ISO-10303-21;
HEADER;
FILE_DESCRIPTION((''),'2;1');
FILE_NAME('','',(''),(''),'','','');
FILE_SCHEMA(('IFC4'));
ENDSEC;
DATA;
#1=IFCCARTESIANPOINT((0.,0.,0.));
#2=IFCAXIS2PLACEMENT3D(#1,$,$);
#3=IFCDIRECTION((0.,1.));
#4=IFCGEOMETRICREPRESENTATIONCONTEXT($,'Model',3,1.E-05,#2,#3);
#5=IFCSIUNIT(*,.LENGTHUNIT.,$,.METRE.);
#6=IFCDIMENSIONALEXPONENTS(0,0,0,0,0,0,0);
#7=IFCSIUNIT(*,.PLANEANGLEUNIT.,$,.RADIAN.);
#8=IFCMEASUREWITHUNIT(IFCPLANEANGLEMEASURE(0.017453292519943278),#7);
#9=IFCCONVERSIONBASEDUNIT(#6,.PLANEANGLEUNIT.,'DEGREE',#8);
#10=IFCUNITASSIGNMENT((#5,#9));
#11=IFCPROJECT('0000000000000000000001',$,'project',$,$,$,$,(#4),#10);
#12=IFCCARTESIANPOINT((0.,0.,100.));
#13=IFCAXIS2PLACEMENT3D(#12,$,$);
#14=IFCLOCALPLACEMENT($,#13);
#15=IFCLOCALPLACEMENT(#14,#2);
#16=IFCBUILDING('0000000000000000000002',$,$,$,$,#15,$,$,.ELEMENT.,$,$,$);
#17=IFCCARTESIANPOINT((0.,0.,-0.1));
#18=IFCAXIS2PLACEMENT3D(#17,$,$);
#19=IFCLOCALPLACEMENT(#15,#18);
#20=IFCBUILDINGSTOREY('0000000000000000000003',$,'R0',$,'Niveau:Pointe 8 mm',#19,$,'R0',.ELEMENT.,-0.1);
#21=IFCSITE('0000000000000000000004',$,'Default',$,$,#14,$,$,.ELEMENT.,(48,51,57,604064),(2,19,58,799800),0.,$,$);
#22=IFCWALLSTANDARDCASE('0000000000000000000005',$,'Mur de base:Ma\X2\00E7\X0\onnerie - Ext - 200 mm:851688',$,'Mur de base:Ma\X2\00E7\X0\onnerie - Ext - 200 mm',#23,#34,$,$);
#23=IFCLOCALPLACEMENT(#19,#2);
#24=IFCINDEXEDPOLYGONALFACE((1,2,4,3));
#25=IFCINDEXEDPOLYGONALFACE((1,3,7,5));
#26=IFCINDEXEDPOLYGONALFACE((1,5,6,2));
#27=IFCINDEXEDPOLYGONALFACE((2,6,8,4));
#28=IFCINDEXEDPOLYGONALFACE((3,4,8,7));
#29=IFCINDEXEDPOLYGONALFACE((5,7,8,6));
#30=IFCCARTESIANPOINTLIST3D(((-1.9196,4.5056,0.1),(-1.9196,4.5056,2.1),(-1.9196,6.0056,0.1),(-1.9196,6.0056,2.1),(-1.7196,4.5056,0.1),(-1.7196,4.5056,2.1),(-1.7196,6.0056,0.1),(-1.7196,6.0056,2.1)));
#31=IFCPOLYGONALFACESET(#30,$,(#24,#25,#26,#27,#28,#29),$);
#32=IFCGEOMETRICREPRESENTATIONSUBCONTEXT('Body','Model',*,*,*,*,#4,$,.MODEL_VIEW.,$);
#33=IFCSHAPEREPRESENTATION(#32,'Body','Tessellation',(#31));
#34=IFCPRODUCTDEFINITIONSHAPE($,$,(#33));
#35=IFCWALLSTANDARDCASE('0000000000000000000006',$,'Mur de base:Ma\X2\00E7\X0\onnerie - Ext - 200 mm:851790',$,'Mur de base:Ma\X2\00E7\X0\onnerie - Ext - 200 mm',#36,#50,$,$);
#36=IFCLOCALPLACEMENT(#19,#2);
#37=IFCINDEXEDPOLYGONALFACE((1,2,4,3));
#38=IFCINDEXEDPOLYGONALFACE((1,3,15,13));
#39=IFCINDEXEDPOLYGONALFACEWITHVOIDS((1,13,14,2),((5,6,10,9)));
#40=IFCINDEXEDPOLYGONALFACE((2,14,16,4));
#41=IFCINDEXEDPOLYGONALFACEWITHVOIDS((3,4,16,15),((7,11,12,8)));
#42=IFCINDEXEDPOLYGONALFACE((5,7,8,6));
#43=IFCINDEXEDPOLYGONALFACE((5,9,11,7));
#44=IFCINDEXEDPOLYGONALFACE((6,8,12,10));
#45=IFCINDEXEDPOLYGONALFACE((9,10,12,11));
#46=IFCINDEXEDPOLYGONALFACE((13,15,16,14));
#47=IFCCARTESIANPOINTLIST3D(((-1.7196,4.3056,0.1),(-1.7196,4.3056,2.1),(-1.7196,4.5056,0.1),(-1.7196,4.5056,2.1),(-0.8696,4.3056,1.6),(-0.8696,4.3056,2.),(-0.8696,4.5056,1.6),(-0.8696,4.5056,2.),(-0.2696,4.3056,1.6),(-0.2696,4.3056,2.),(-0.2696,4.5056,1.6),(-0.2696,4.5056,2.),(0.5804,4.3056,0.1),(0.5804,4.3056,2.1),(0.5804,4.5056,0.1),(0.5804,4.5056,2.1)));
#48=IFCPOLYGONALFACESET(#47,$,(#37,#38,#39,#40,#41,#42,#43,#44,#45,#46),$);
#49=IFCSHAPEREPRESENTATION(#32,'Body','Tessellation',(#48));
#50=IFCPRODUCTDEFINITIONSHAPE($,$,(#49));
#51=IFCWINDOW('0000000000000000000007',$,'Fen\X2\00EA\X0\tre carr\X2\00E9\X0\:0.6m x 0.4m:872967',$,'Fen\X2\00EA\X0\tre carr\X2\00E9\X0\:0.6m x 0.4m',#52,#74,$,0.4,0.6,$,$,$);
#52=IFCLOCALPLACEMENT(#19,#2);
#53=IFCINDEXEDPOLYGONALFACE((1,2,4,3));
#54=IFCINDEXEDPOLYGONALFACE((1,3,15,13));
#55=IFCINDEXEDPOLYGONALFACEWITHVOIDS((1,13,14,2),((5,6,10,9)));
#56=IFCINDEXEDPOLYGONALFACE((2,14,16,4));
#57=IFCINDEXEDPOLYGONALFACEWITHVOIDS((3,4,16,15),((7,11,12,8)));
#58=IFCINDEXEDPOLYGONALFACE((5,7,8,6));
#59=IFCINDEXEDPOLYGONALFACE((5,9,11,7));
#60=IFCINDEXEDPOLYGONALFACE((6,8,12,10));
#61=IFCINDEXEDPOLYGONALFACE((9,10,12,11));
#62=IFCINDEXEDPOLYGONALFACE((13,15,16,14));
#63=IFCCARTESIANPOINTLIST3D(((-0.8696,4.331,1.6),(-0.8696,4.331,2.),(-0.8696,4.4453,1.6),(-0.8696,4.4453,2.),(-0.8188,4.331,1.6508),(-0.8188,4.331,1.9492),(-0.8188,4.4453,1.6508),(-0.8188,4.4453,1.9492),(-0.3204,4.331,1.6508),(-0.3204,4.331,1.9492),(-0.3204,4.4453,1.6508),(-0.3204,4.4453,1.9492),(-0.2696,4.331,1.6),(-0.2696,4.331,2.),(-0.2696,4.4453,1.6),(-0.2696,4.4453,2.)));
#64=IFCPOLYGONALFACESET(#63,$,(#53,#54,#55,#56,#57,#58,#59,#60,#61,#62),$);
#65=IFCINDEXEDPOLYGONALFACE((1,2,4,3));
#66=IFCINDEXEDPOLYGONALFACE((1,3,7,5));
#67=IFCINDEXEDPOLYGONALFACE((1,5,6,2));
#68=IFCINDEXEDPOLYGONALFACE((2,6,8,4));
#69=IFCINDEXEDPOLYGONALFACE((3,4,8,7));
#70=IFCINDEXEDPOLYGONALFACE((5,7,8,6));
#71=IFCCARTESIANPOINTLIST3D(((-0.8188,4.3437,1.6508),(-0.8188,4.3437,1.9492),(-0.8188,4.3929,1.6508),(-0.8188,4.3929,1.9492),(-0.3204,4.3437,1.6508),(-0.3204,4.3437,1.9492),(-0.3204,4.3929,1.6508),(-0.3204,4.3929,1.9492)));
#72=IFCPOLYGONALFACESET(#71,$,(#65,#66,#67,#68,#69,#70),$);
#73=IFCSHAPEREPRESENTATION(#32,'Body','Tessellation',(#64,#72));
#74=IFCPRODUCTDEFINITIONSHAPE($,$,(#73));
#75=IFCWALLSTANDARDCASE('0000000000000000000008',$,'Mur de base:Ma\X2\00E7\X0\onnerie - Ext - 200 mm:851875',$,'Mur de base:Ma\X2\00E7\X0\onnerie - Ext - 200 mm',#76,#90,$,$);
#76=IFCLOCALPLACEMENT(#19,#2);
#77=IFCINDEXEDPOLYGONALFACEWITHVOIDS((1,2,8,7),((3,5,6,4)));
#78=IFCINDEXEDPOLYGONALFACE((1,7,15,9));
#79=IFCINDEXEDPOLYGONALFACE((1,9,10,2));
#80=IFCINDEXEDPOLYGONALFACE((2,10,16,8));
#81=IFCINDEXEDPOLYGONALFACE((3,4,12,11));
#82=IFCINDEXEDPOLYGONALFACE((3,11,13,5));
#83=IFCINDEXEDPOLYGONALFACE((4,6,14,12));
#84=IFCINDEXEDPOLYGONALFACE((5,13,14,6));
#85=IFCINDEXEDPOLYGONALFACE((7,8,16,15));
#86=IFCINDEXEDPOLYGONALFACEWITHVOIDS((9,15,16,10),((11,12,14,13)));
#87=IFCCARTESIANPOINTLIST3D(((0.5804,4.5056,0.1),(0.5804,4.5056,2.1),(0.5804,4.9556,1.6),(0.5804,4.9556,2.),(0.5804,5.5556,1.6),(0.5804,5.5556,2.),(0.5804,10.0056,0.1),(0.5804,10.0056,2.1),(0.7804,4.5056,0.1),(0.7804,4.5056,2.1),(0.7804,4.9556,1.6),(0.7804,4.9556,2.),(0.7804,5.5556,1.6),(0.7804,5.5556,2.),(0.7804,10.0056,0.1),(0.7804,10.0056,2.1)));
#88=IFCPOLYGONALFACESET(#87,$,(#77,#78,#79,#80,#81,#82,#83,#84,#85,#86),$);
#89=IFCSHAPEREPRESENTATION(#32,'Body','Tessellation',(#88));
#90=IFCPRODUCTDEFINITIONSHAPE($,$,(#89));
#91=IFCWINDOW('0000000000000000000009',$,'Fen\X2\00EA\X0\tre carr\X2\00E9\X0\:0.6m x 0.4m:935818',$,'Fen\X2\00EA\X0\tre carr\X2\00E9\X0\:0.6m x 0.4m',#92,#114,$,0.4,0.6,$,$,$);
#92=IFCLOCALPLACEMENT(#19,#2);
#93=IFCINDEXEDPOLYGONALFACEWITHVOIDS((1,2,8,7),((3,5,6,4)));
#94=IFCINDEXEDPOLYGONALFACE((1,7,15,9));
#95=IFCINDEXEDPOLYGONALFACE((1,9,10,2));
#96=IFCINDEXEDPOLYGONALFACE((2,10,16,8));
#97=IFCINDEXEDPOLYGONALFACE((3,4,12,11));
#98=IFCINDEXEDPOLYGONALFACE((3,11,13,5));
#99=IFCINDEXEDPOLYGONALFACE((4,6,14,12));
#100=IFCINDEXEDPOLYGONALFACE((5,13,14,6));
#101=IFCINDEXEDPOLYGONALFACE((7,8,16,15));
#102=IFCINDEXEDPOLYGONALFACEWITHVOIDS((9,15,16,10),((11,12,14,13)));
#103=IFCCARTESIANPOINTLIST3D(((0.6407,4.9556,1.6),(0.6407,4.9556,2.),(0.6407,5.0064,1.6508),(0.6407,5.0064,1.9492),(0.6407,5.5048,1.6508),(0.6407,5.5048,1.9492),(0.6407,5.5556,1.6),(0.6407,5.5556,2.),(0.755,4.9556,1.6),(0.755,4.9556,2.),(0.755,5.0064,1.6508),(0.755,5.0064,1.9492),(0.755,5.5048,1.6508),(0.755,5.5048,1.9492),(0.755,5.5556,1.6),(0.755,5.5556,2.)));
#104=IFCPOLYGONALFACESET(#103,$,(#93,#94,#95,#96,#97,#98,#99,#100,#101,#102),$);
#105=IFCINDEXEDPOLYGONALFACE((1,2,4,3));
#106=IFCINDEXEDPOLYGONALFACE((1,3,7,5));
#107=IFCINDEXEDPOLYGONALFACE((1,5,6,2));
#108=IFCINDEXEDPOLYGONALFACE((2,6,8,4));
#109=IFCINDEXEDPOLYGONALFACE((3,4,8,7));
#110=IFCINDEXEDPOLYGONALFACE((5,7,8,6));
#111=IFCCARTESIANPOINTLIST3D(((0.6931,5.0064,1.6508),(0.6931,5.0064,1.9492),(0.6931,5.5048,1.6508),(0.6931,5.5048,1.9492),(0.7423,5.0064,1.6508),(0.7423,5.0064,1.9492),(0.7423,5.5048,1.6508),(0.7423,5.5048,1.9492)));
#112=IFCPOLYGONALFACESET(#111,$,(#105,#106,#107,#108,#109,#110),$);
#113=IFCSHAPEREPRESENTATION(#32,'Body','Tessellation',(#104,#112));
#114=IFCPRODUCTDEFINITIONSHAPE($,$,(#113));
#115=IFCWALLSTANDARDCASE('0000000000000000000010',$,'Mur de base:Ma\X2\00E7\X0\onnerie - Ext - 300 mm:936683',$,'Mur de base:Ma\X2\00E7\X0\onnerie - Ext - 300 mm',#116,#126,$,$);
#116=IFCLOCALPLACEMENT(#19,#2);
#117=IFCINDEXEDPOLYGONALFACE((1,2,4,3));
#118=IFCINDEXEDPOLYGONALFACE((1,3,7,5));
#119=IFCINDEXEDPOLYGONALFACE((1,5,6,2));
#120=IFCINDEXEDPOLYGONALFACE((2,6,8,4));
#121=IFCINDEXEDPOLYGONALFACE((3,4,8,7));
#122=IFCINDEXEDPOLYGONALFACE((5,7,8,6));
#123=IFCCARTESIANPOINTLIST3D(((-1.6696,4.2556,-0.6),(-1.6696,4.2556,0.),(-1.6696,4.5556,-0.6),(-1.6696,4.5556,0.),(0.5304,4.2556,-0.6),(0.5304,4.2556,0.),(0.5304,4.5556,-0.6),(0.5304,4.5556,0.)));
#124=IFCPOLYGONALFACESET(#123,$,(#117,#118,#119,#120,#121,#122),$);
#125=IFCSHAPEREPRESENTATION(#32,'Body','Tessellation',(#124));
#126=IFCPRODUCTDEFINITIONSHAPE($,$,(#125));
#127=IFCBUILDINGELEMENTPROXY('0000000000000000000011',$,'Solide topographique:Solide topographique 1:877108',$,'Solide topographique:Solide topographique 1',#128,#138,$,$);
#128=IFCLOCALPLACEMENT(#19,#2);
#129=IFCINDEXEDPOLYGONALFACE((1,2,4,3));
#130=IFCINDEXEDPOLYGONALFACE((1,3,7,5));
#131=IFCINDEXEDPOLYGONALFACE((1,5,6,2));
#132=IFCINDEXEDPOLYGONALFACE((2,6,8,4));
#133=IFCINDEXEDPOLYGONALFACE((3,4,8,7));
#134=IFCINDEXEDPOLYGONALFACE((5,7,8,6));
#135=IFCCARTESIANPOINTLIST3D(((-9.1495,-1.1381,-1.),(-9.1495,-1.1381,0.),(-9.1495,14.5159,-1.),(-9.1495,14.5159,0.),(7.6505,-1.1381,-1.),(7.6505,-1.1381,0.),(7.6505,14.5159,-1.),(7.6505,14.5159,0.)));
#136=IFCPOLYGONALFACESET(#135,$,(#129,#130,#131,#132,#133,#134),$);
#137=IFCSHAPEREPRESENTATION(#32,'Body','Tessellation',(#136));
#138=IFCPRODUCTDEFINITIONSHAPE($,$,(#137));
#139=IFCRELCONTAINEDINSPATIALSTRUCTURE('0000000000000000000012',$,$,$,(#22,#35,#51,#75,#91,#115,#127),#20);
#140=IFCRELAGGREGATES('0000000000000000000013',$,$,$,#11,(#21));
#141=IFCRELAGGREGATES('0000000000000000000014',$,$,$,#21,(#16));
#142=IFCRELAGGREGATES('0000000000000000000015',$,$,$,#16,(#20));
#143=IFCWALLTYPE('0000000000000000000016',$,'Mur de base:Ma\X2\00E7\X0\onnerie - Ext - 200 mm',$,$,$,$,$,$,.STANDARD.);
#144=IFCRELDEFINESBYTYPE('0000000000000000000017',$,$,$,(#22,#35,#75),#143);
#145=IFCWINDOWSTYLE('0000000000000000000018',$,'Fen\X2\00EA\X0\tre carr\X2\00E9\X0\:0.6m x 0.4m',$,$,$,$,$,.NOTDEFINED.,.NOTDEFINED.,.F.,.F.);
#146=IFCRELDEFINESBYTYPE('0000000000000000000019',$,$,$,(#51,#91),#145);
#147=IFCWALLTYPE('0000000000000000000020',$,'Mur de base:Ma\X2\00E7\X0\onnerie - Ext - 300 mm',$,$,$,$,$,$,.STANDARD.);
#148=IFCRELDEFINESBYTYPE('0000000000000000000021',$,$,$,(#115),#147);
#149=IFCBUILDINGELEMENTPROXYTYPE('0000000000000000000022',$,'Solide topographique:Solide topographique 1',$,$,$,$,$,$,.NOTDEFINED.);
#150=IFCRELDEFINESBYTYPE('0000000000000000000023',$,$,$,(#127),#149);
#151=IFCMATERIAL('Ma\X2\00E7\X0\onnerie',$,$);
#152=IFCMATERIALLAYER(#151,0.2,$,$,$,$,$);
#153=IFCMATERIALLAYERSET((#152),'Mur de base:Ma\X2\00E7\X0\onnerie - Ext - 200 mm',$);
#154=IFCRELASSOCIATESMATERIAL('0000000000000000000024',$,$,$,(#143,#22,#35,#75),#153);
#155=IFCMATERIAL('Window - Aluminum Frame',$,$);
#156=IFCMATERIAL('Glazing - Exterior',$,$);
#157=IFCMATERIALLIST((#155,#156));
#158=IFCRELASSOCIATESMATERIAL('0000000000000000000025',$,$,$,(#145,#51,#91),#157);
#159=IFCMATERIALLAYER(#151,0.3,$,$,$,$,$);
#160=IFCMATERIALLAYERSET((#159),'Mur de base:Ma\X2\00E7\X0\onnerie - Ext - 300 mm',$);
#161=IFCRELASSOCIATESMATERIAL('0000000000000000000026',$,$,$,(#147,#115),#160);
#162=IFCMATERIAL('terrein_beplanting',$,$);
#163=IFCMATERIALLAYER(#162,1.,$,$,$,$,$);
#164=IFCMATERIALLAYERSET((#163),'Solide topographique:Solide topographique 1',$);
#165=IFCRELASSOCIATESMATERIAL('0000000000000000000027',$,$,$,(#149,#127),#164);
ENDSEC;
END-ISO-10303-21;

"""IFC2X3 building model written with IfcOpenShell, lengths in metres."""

from ifc_helpers import new_model, entity, si_unit, converted_unit, direction, frame, frame_2d, origin, place, context, subcontext, project, spatial, polyline, rectangle, outline, extrude, clip, bounded_halfspace, source, transform, mapped, material, material_list, layer, layer_set, layer_usage, type_object, type_shapes, element, fill, save


model = new_model("IFC2X3")

# Units and contexts
model_context = context("Model", 3, precision=1e-05, world=origin(), true_north=direction((0.0, 1.0)))
body_context = subcontext(model_context, "Body", "Model", "MODEL_VIEW")
ifc_project = project(units=[si_unit("LENGTHUNIT", "METRE"), converted_unit("PLANEANGLEUNIT", "DEGREE", entity("IfcPlaneAngleMeasure", 0.017453292519943278), si_unit("PLANEANGLEUNIT", "RADIAN"), dimensions=[0, 0, 0, 0, 0, 0, 0])], contexts=[model_context])

# Site, building, storey
site_placement = place(None, frame((0.0, 0.0, 100.0)))
site = spatial("IfcSite", under=ifc_project, at=site_placement, Name="Default", CompositionType="ELEMENT", RefLatitude=(48, 51, 57, 604064), RefLongitude=(2, 19, 58, 799800), RefElevation=0.0)
building_placement = place(site_placement, origin())
building = spatial("IfcBuilding", under=site, at=building_placement, CompositionType="ELEMENT")
storey_placement = place(building_placement, frame((0.0, 0.0, -0.1)))
storey = spatial("IfcBuildingStorey", under=building, at=storey_placement, Name="R0", ObjectType="Niveau:Pointe 8 mm", LongName="R0", CompositionType="ELEMENT", Elevation=-0.1)

# Wall
ifc_material_1 = material(Name="Maçonnerie")
ifc_layer_1 = layer(ifc_material_1, 0.2)
ifc_layer_set_1 = layer_set([ifc_layer_1], Name="Mur de base:Maçonnerie - Ext - 200 mm")
ifc_layer_usage_1 = layer_usage(ifc_layer_set_1, "AXIS2", "NEGATIVE", 0.1)
wall_type_1 = type_object("IfcWallType", Name="Mur de base:Maçonnerie - Ext - 200 mm", PredefinedType="STANDARD", material=ifc_layer_set_1)
wall_1_placement = place(storey_placement, frame((-1.8196, 4.5056, 0.1), z_axis=(0.0, 0.0, 1.0), x_axis=(0.0, 1.0, 0.0)))
element("IfcWallStandardCase", 1, at=wall_1_placement, inside=storey, type_object=wall_type_1, material=ifc_layer_usage_1, Name="Mur de base:Maçonnerie - Ext - 200 mm:851688", ObjectType="Mur de base:Maçonnerie - Ext - 200 mm", context=body_context, shape_type="Clipping", body=[
    clip(extrude(rectangle(XDim=1.5, YDim=0.2, at=frame_2d((0.75, 0.0), x_axis=(-1.0, 0.0))), origin(), (0.0, 0.0, 1.0), 2.0), bounded_halfspace(frame((0.0, -0.1, 0.0), z_axis=(1.0, 0.0, 0.0), x_axis=(0.0, 0.0, -1.0)), True, frame((0.0, -0.1, 0.0), z_axis=(1.0, 0.0, 0.0), x_axis=(0.0, 0.0, -1.0)), polyline([(0.0, 0.0), (0.0, 0.2), (-2.0, 0.2), (-2.0, 0.0), (0.0, 0.0)]))),
])

# Walls, openings, windows
ifc_layer_usage_2 = layer_usage(ifc_layer_set_1, "AXIS2", "NEGATIVE", 0.1)
wall_2_placement = place(storey_placement, frame((-1.7196, 4.4056, 0.1)))
wall_2 = element("IfcWallStandardCase", 2, at=wall_2_placement, inside=storey, type_object=wall_type_1, material=ifc_layer_usage_2, Name="Mur de base:Maçonnerie - Ext - 200 mm:851790", ObjectType="Mur de base:Maçonnerie - Ext - 200 mm", context=body_context, shape_type="Clipping", body=[
    clip(extrude(rectangle(XDim=2.3, YDim=0.2, at=frame_2d((1.15, 0.0), x_axis=(-1.0, 0.0))), origin(), (0.0, 0.0, 1.0), 2.0), bounded_halfspace(frame((2.3, -0.1, 2.0), z_axis=(-1.0, 0.0, 0.0), x_axis=(0.0, 0.0, -1.0)), True, frame((2.3, -0.1, 2.0), z_axis=(-1.0, 0.0, 0.0), x_axis=(0.0, 0.0, -1.0)), polyline([(0.0, 0.0), (0.0, -0.2), (2.0, -0.2), (2.0, 0.0), (0.0, 0.0)]))),
])
opening_1_placement = place(wall_2_placement, frame((1.45, 0.1, 1.5)))
opening_1 = element("IfcOpeningElement", 3, at=opening_1_placement, cuts=wall_2, ObjectType="Opening", context=body_context, shape_type="SweptSolid", body=[
    extrude(rectangle(XDim=0.4, YDim=0.6, at=frame_2d((0.2, 0.3), x_axis=(-1.0, 0.0))), frame((0.0, 0.0, 0.0), z_axis=(0.0, -1.0, 0.0), x_axis=(0.0, 0.0, 1.0)), (0.0, 0.0, 1.0), 0.2),
])
ifc_material_2 = material(Name="Window - Aluminum Frame")
ifc_material_3 = material(Name="Glazing - Exterior")
ifc_material_list = material_list([ifc_material_2, ifc_material_3])
window_style = type_object("IfcWindowStyle", Name="Fenêtre carré:0.6m x 0.4m", ConstructionType="NOTDEFINED", OperationType="NOTDEFINED", ParameterTakesPrecedence=False, Sizeable=False, material=ifc_material_list)
shared_shape_1 = source(origin(), body_context, "Body", "SweptSolid", [
    extrude(outline(polyline([(-0.3, -0.2), (0.3, -0.2), (0.3, 0.2), (-0.3, 0.2), (-0.3, -0.2)]), holes=[polyline([(-0.2492, -0.1492), (-0.2492, 0.1492), (0.2492, 0.1492), (0.2492, -0.1492), (-0.2492, -0.1492)])]), frame((0.3, 0.0603, 0.2), z_axis=(0.0, 1.0, 0.0), x_axis=(1.0, 0.0, 0.0)), (0.0, 0.0, 1.0), 0.1143),
    extrude(rectangle(XDim=0.0492, YDim=0.4984, at=frame_2d((0.0, 0.0), x_axis=(1.0, 0.0))), frame((0.3, 0.1373, 0.0508), z_axis=(0.0, 0.0, 1.0), x_axis=(0.0, -1.0, 0.0)), (0.0, 0.0, 1.0), 0.2984),
])
type_shapes(window_style, [shared_shape_1])
window_1_placement = place(opening_1_placement, frame((0.0, 0.0, 0.0), z_axis=(0.0, 0.0, 1.0), x_axis=(-1.0, 0.0, 0.0)))
window_1 = element("IfcWindow", 4, at=window_1_placement, inside=storey, type_object=window_style, material=ifc_material_list, Name="Fenêtre carré:0.6m x 0.4m:872967", ObjectType="Fenêtre carré:0.6m x 0.4m", OverallHeight=0.4, OverallWidth=0.6, context=body_context, shape_type="MappedRepresentation", body=[
    mapped(shared_shape_1, transform((0.0, 0.0, 0.0), scale=1.0)),
])
fill(opening_1, window_1)
ifc_layer_usage_3 = layer_usage(ifc_layer_set_1, "AXIS2", "NEGATIVE", 0.1)
wall_3_placement = place(storey_placement, frame((0.6804, 4.5056, 0.1), z_axis=(0.0, 0.0, 1.0), x_axis=(0.0, 1.0, 0.0)))
wall_3 = element("IfcWallStandardCase", 5, at=wall_3_placement, inside=storey, type_object=wall_type_1, material=ifc_layer_usage_3, Name="Mur de base:Maçonnerie - Ext - 200 mm:851875", ObjectType="Mur de base:Maçonnerie - Ext - 200 mm", context=body_context, shape_type="SweptSolid", body=[
    extrude(rectangle(XDim=5.5, YDim=0.2, at=frame_2d((2.75, 0.0), x_axis=(-1.0, 0.0))), origin(), (0.0, 0.0, 1.0), 2.0),
])
opening_2_placement = place(wall_3_placement, frame((1.05, 0.1, 1.5)))
opening_2 = element("IfcOpeningElement", 6, at=opening_2_placement, cuts=wall_3, ObjectType="Opening", context=body_context, shape_type="SweptSolid", body=[
    extrude(rectangle(XDim=0.4, YDim=0.6, at=frame_2d((0.2, 0.3), x_axis=(-1.0, 0.0))), frame((0.0, 0.0, 0.0), z_axis=(0.0, -1.0, 0.0), x_axis=(0.0, 0.0, 1.0)), (0.0, 0.0, 1.0), 0.2),
])
window_2_placement = place(opening_2_placement, frame((0.0, 0.0, 0.0), z_axis=(0.0, 0.0, 1.0), x_axis=(-1.0, 0.0, 0.0)))
window_2 = element("IfcWindow", 7, at=window_2_placement, inside=storey, type_object=window_style, material=ifc_material_list, Name="Fenêtre carré:0.6m x 0.4m:935818", ObjectType="Fenêtre carré:0.6m x 0.4m", OverallHeight=0.4, OverallWidth=0.6, context=body_context, shape_type="MappedRepresentation", body=[
    mapped(shared_shape_1, transform((0.0, 0.0, 0.0), scale=1.0)),
])
fill(opening_2, window_2)

# Wall
ifc_layer_2 = layer(ifc_material_1, 0.3)
ifc_layer_set_2 = layer_set([ifc_layer_2], Name="Mur de base:Maçonnerie - Ext - 300 mm")
ifc_layer_usage_4 = layer_usage(ifc_layer_set_2, "AXIS2", "NEGATIVE", 0.15)
wall_type_2 = type_object("IfcWallType", Name="Mur de base:Maçonnerie - Ext - 300 mm", PredefinedType="STANDARD", material=ifc_layer_set_2)
wall_4_placement = place(storey_placement, frame((-1.6696, 4.4056, -0.6)))
element("IfcWallStandardCase", 8, at=wall_4_placement, inside=storey, type_object=wall_type_2, material=ifc_layer_usage_4, Name="Mur de base:Maçonnerie - Ext - 300 mm:936683", ObjectType="Mur de base:Maçonnerie - Ext - 300 mm", context=body_context, shape_type="Clipping", body=[
    clip(extrude(rectangle(XDim=2.2, YDim=0.3, at=frame_2d((1.1, 0.0), x_axis=(-1.0, 0.0))), origin(), (0.0, 0.0, 1.0), 0.6), bounded_halfspace(frame((2.2, -0.15, 0.6), z_axis=(-1.0, 0.0, 0.0), x_axis=(0.0, 0.0, -1.0)), True, frame((2.2, -0.15, 0.6), z_axis=(-1.0, 0.0, 0.0), x_axis=(0.0, 0.0, -1.0)), polyline([(0.0, 0.0), (0.0, -0.25), (0.0, -0.3), (0.6, -0.3), (0.6, 0.0), (0.0, 0.0)]))),
])

# Building element proxy
ifc_material_4 = material(Name="terrein_beplanting")
ifc_layer_3 = layer(ifc_material_4, 1.0)
ifc_layer_set_3 = layer_set([ifc_layer_3], Name="Solide topographique:Solide topographique 1")
ifc_layer_usage_5 = layer_usage(ifc_layer_set_3, "AXIS3", "NEGATIVE", 0.0)
building_element_proxy_type = type_object("IfcBuildingElementProxyType", Name="Solide topographique:Solide topographique 1", PredefinedType="NOTDEFINED", material=ifc_layer_set_3)
proxy_placement = place(storey_placement, origin())
element("IfcBuildingElementProxy", 9, at=proxy_placement, inside=storey, type_object=building_element_proxy_type, material=ifc_layer_usage_5, Name="Solide topographique:Solide topographique 1:877108", ObjectType="Solide topographique:Solide topographique 1", context=body_context, shape_type="SweptSolid", body=[
    extrude(rectangle(XDim=16.8, YDim=15.654, at=frame_2d((0.0, 0.0), x_axis=(1.0, 0.0))), frame((-0.7495, 6.6889, -1.0), z_axis=(0.0, 0.0, 1.0), x_axis=(-1.0, 0.0, 0.0)), (0.0, 0.0, 1.0), 1.0),
])

save(model, "model.ifc")
